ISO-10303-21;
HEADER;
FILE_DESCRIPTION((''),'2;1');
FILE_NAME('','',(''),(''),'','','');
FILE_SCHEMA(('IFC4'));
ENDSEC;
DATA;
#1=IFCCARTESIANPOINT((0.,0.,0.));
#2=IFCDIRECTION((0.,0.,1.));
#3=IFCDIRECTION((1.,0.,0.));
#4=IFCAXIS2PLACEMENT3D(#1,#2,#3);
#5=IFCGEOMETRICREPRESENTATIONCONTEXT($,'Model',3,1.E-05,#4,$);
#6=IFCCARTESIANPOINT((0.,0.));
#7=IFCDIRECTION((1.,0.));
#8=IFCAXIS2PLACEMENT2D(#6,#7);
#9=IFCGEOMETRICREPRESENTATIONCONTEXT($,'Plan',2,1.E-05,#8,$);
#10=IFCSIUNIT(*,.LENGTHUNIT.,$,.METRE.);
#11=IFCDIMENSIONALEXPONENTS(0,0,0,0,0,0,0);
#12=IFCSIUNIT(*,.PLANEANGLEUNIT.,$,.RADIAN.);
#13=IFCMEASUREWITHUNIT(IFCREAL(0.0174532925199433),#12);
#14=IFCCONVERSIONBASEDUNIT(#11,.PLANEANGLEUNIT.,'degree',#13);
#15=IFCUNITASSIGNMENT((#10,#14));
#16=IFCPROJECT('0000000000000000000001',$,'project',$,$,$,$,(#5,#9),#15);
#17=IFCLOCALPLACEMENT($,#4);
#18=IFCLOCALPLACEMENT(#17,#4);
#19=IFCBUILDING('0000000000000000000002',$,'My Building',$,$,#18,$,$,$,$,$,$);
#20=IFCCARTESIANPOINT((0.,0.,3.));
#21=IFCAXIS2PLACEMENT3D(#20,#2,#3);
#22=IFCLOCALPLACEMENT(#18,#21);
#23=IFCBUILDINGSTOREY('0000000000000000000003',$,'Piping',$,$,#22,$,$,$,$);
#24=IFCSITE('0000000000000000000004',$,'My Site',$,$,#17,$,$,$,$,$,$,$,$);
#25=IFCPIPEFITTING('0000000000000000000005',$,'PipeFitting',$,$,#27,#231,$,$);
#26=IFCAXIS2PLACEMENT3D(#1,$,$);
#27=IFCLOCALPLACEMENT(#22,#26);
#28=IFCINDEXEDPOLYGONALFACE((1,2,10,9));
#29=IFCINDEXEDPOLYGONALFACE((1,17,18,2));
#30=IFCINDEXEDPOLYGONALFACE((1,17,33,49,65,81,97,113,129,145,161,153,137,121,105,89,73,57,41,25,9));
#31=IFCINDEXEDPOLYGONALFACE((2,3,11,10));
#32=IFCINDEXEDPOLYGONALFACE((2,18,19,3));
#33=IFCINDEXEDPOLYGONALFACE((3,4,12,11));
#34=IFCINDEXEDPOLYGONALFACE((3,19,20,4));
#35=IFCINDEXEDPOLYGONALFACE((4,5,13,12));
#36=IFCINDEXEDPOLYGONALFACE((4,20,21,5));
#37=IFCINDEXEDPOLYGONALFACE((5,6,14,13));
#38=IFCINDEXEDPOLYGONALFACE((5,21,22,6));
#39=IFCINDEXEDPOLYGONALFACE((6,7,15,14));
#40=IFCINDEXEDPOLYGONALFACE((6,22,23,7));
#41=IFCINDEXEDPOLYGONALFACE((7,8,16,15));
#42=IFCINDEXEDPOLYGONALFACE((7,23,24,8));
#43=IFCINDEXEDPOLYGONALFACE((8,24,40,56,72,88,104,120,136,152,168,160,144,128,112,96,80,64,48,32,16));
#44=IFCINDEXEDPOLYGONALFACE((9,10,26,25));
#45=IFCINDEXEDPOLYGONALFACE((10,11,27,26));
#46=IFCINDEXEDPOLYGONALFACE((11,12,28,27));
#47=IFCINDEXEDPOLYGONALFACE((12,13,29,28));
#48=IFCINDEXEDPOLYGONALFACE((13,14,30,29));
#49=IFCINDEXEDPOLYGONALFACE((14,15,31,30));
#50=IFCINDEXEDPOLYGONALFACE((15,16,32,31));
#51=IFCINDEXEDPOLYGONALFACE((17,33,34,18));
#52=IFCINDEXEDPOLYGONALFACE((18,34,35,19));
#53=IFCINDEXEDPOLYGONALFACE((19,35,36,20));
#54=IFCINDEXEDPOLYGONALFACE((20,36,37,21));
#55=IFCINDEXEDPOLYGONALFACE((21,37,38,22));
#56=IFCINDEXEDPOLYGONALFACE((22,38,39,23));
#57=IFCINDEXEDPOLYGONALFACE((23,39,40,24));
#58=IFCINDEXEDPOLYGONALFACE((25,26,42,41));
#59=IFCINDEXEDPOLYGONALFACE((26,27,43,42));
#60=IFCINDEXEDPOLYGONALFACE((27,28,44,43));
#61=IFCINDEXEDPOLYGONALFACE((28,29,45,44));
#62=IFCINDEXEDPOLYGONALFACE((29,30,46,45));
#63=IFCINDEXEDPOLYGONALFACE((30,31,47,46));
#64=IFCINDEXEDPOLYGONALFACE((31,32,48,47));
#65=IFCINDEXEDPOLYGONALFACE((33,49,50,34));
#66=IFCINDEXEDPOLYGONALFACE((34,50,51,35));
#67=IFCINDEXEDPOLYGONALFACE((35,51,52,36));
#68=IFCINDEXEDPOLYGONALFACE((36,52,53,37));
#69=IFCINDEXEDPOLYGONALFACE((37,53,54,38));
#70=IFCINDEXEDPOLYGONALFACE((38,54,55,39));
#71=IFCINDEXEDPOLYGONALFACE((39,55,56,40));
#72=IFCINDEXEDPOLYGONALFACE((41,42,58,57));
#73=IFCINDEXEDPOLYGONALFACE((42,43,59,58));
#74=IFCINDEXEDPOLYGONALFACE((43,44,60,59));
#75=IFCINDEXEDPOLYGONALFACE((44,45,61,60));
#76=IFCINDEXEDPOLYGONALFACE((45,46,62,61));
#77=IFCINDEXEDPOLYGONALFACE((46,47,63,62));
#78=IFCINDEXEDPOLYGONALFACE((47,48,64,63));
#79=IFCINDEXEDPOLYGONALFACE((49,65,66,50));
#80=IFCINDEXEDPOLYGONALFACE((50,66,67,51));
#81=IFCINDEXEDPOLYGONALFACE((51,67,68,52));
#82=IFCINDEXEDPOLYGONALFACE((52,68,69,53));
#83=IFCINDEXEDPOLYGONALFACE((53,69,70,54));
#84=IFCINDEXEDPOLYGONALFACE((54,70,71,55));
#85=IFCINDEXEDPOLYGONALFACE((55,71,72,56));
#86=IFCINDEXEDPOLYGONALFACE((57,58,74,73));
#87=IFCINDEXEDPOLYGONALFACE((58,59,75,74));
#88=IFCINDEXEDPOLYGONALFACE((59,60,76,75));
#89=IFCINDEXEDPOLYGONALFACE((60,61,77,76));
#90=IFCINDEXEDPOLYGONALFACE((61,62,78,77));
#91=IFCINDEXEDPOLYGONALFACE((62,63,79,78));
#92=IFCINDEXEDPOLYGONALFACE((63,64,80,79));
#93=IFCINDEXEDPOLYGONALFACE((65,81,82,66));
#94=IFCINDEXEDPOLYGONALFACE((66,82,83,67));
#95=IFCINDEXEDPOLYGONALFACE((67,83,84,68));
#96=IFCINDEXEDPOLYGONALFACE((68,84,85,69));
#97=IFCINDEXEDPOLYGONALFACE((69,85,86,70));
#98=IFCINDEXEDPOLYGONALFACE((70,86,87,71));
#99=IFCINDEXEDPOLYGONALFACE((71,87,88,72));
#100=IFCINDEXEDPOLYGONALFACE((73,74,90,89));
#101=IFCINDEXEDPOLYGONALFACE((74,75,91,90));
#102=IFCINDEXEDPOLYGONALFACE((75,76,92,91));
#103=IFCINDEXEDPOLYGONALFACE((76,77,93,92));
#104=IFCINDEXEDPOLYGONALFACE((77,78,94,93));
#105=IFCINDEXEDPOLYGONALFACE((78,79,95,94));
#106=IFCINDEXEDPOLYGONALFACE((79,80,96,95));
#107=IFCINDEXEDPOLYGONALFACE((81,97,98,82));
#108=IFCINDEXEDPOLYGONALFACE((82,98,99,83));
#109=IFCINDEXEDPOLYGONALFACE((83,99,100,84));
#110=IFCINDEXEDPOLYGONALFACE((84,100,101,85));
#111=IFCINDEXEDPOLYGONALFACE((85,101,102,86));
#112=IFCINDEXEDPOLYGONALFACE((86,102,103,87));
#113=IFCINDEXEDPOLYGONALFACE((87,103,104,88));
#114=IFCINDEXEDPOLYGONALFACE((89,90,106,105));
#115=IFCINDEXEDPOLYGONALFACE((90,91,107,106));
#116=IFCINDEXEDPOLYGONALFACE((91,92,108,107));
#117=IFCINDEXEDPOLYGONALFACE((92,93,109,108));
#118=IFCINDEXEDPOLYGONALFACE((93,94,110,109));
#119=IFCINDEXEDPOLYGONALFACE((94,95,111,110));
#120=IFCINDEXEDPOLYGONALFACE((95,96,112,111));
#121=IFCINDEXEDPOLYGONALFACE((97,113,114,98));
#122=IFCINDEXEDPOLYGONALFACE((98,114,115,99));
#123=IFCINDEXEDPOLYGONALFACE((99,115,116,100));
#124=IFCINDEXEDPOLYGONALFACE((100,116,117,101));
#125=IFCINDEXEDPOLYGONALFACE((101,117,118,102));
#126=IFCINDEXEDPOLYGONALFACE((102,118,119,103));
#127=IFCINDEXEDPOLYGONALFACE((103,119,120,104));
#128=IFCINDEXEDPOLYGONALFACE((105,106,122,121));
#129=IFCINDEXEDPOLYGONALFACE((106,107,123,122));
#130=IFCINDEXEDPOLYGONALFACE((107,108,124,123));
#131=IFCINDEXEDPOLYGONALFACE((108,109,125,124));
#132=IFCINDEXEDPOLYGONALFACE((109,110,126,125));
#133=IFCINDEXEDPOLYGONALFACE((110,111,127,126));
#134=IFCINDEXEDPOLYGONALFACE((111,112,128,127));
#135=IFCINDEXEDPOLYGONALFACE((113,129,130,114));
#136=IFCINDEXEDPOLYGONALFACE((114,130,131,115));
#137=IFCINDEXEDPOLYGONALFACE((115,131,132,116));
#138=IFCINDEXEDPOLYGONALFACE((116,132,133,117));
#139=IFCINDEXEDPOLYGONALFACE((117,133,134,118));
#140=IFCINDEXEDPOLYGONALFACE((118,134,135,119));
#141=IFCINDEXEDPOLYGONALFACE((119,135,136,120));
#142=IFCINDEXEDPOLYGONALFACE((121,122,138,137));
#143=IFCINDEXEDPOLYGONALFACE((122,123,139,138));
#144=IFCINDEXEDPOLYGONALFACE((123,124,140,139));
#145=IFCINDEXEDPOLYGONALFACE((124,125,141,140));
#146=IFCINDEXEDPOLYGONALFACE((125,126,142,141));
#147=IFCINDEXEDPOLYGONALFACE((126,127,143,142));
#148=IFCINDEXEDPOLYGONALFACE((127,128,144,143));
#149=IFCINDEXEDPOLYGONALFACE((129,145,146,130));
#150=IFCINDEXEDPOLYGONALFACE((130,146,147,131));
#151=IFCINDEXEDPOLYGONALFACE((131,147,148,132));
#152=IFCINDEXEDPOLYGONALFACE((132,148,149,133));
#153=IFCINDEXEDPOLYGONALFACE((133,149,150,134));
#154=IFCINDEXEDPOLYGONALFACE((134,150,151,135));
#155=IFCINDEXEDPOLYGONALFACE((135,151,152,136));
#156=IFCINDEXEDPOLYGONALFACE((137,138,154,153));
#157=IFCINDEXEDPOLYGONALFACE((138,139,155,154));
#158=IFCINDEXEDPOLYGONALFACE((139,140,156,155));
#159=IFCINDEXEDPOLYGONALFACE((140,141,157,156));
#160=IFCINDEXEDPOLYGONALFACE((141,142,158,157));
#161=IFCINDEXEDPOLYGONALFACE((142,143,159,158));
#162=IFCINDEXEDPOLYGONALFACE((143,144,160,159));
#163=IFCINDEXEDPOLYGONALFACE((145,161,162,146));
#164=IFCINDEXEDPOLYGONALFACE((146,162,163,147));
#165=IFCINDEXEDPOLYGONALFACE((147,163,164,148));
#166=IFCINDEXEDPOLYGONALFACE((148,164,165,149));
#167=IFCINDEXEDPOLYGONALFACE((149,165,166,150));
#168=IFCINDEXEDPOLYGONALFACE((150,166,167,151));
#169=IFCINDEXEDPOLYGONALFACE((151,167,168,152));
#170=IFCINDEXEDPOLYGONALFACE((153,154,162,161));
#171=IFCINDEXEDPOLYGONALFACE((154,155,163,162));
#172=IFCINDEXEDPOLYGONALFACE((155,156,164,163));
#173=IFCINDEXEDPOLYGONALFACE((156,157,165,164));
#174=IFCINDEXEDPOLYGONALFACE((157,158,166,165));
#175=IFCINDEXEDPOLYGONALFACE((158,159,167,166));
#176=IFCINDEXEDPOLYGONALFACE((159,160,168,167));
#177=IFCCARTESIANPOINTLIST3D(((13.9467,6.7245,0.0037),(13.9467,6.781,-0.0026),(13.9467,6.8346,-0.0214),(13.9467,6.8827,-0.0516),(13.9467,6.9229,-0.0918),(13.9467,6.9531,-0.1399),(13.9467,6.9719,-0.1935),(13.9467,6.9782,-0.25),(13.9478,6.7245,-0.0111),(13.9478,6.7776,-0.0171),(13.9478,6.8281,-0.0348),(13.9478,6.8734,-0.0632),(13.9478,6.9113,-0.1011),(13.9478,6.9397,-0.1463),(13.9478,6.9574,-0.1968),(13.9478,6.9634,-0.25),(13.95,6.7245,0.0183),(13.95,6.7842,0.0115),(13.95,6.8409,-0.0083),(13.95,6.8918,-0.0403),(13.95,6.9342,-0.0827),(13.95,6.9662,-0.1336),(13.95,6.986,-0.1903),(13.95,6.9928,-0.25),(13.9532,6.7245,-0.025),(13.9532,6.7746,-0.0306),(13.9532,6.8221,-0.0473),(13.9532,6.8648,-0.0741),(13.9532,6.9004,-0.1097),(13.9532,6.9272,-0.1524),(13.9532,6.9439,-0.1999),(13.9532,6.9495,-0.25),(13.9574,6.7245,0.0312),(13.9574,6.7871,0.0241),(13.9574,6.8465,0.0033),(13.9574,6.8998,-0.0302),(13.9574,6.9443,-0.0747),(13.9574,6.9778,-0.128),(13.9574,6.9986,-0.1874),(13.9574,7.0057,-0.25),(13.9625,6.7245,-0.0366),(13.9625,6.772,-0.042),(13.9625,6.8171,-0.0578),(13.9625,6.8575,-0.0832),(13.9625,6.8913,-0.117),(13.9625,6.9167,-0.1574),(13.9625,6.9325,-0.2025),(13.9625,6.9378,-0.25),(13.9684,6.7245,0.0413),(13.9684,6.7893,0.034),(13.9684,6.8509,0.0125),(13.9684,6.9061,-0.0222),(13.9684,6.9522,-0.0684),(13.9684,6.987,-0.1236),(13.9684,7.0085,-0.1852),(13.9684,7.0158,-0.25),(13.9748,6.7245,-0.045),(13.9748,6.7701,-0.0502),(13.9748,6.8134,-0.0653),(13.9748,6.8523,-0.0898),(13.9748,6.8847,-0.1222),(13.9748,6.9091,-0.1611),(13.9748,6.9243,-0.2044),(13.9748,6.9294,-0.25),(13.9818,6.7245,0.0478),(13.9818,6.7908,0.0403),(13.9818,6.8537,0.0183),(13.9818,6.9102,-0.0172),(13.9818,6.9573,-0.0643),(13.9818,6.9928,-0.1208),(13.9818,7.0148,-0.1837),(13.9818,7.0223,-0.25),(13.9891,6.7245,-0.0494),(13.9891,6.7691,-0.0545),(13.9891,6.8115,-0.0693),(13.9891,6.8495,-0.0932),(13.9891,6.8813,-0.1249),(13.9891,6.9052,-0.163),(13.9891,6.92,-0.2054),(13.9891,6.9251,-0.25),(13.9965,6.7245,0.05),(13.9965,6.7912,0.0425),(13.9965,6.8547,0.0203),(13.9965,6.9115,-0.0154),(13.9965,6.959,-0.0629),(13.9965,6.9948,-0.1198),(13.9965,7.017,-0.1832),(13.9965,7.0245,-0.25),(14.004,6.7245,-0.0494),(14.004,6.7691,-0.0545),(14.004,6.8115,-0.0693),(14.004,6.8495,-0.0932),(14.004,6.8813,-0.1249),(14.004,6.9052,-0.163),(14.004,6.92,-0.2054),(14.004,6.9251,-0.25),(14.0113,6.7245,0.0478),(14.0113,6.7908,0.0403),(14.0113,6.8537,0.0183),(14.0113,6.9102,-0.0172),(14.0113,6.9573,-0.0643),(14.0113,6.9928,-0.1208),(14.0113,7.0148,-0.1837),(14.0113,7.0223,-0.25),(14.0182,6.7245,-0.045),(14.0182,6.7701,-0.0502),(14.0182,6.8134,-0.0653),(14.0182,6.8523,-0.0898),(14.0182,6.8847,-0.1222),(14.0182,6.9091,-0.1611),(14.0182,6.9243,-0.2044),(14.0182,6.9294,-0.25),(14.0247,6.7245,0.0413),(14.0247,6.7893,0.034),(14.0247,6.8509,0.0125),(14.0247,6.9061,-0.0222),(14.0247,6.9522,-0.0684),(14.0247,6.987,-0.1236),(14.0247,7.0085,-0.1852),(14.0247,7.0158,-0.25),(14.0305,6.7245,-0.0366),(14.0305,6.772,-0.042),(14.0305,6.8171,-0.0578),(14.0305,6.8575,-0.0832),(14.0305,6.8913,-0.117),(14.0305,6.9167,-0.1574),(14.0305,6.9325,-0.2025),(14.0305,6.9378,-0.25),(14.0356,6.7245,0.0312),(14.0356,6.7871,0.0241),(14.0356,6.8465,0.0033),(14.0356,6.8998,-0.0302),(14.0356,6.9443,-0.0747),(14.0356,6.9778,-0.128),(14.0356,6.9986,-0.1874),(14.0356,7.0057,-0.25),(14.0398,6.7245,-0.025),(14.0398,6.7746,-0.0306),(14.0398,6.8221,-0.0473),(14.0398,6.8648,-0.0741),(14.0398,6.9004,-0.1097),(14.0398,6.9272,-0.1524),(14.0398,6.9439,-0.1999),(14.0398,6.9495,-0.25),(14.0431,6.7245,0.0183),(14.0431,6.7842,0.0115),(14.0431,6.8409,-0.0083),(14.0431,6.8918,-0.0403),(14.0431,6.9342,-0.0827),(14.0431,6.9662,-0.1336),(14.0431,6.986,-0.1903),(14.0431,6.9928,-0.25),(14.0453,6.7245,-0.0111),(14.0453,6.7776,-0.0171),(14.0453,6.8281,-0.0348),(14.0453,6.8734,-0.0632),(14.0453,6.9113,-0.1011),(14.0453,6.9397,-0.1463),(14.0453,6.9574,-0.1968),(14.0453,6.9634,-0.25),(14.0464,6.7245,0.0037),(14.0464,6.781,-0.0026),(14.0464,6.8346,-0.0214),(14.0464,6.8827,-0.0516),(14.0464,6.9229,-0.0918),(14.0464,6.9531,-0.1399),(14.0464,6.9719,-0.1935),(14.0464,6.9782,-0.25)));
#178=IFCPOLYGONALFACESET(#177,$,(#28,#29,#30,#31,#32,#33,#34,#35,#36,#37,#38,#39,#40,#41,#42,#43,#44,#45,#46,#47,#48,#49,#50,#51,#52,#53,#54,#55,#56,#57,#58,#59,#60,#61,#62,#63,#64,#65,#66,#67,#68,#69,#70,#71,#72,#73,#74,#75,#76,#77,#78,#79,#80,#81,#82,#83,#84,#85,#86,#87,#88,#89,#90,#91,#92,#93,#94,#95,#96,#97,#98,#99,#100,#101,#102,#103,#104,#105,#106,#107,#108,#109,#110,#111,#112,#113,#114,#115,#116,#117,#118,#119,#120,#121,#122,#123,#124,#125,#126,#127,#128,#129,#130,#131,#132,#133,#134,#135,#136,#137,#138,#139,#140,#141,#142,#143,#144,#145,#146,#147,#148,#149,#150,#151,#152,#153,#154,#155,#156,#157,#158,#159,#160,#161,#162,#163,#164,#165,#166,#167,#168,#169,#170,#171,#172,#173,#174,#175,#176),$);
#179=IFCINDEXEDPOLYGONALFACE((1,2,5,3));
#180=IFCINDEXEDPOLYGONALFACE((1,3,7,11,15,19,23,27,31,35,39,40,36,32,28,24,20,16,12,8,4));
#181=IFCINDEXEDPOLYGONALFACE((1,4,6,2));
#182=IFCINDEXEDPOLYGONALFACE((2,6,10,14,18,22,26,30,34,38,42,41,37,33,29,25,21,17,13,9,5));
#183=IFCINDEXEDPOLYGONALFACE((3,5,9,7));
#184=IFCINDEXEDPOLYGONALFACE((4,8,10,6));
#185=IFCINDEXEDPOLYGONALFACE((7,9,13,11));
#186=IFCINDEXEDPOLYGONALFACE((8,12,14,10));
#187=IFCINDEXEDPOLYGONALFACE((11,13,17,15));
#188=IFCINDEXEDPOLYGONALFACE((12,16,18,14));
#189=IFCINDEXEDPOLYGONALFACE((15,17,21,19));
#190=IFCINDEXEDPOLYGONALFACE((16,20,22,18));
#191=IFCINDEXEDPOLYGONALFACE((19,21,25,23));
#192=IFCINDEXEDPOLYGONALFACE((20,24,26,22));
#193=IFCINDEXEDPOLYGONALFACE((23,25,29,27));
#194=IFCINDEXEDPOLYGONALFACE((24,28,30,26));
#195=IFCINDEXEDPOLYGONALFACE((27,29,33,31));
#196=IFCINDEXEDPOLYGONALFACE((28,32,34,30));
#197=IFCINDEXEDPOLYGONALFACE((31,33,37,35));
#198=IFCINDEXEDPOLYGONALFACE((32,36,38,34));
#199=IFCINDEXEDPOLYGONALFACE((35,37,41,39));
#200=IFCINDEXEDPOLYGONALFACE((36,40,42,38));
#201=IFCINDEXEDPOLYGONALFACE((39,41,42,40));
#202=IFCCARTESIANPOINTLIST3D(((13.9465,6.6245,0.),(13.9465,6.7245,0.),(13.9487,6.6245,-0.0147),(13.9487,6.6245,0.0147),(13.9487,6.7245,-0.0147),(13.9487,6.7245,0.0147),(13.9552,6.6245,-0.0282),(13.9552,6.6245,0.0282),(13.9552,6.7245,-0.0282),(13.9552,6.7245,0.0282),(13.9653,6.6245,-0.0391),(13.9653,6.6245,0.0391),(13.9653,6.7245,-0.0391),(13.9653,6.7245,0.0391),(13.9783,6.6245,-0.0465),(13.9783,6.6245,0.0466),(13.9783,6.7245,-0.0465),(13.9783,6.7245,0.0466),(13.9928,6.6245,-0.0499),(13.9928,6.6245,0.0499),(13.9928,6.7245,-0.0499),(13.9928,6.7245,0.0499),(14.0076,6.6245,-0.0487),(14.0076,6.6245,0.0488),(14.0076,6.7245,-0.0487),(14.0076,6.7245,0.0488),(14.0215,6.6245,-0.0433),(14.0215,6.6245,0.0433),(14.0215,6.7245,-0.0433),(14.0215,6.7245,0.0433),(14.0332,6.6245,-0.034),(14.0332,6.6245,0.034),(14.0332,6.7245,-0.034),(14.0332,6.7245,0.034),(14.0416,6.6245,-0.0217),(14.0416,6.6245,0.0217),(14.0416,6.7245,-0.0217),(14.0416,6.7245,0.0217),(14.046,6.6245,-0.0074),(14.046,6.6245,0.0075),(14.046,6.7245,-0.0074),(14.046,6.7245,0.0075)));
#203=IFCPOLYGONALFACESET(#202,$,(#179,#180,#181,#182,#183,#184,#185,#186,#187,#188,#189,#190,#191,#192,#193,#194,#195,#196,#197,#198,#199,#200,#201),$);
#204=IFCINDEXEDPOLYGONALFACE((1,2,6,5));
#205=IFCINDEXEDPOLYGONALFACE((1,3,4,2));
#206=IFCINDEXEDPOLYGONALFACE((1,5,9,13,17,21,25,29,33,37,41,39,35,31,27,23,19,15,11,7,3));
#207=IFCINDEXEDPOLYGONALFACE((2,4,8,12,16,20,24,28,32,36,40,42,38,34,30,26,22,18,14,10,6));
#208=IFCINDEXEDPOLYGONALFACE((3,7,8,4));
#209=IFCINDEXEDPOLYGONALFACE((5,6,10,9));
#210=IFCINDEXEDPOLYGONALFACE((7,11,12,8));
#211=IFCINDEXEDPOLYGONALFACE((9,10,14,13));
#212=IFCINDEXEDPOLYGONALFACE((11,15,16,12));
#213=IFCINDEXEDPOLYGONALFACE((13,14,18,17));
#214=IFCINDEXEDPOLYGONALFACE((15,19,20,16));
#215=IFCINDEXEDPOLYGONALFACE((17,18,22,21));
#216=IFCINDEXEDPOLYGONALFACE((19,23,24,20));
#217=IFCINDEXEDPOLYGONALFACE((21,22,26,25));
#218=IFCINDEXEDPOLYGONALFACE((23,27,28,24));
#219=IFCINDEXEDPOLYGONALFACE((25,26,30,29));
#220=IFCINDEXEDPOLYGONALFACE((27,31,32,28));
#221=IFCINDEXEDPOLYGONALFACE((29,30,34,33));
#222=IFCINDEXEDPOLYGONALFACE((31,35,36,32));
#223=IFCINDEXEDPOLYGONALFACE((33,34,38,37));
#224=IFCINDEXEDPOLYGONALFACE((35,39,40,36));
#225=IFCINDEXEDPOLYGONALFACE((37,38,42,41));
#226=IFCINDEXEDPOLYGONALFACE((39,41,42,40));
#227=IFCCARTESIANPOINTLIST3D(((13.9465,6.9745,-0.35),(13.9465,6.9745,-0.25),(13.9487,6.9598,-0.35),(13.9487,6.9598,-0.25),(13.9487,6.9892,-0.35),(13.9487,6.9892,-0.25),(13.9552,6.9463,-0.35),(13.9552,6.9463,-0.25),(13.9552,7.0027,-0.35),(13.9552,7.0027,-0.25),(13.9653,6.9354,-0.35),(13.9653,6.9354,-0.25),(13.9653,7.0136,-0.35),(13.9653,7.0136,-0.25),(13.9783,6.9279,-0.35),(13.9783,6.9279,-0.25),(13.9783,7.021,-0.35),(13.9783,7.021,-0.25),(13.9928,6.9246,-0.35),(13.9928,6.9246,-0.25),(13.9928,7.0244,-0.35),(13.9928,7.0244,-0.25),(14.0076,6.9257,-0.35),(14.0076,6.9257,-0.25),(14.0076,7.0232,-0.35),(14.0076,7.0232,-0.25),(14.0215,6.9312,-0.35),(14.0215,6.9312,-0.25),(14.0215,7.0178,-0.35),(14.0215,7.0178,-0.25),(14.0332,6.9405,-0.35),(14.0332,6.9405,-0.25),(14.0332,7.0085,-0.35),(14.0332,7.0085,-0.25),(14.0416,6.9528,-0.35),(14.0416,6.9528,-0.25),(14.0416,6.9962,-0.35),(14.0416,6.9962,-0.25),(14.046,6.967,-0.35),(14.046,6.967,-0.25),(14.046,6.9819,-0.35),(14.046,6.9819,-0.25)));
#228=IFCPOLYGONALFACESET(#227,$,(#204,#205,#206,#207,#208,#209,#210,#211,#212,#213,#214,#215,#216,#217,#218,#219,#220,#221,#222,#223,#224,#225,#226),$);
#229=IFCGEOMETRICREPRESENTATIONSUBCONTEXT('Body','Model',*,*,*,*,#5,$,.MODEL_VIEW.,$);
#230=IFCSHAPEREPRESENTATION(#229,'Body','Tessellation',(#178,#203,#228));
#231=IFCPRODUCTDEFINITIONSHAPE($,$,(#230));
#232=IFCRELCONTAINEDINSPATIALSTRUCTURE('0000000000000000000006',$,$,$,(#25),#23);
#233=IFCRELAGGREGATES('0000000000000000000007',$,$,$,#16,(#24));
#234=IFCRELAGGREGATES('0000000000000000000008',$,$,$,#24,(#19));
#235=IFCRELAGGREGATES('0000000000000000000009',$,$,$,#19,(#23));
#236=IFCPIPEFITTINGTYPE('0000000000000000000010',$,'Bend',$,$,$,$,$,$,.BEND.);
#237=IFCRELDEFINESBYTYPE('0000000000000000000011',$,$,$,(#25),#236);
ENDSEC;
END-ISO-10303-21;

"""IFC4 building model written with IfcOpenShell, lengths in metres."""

from ifc_helpers import new_model, entity, si_unit, converted_unit, frame, origin_with_axes, origin_2d_with_axis, place, context, subcontext, project, spatial, circle, extrude, source, transform, mapped, type_object, type_shapes, element, save


model = new_model("IFC4")

# Units and contexts
model_context = context("Model", 3, precision=1e-05, world=origin_with_axes())
plan_context = context("Plan", 2, precision=1e-05, world=origin_2d_with_axis())
body_context = subcontext(model_context, "Body", "Model", "MODEL_VIEW")
ifc_project = project(units=[si_unit("LENGTHUNIT", "METRE"), converted_unit("PLANEANGLEUNIT", "degree", entity("IfcReal", 0.0174532925199433), si_unit("PLANEANGLEUNIT", "RADIAN"), dimensions=[0, 0, 0, 0, 0, 0, 0])], contexts=[model_context, plan_context])

# Site, building, storey
site_placement = place(None, origin_with_axes())
site = spatial("IfcSite", under=ifc_project, at=site_placement, Name="My Site")
building_placement = place(site_placement, origin_with_axes())
building = spatial("IfcBuilding", under=site, at=building_placement, Name="My Building")
storey_placement = place(building_placement, frame((0.0, 0.0, 3.0), z_axis=(0.0, 0.0, 1.0), x_axis=(1.0, 0.0, 0.0)))
storey = spatial("IfcBuildingStorey", under=building, at=storey_placement, Name="Piping")

# Pipe fitting
pipe_fitting_type = type_object("IfcPipeFittingType", Name="Bend", PredefinedType="BEND")
shared_shape = source(origin_with_axes(), body_context, "Body", "SolidModel", [
    entity("IfcSweptDiskSolid", entity("IfcIndexedPolyCurve", entity("IfcCartesianPointList3D", [[0.0, 0.0, 0.1], [0.0, -0.0732, 0.2768], [0.0, -0.25, 0.35]]), [entity("IfcArcIndex", [1, 2, 3])]), 0.05),
    extrude(circle(Radius=0.05), origin_with_axes(), (0.0, 0.0, 1.0), 0.1),
    extrude(circle(Radius=0.05), frame((0.0, -0.25, 0.35), z_axis=(0.0, -1.0, 0.0), x_axis=(1.0, 0.0, 0.0)), (0.0, 0.0, 1.0), 0.1),
])
type_shapes(pipe_fitting_type, [shared_shape])
for number, where, z_axis, x_axis, name in (
    (1, (13.9965, 6.6245, 0.0), (0.0, 1.0, 0.0), (-1.0, 0.0, 0.0), "PipeFitting"),
):
    element("IfcPipeFitting", number, at=place(storey_placement, frame(where, z_axis=z_axis, x_axis=x_axis)), inside=storey, type_object=pipe_fitting_type, Name=name, context=body_context, shape_type="MappedRepresentation", body=[
        mapped(shared_shape, transform((0.0, 0.0, 0.0), x_axis=(1.0, 0.0, 0.0), y_axis=(0.0, 1.0, 0.0), z_axis=(0.0, 0.0, 1.0), scale=1.0)),
    ])

save(model, "model.ifc")
